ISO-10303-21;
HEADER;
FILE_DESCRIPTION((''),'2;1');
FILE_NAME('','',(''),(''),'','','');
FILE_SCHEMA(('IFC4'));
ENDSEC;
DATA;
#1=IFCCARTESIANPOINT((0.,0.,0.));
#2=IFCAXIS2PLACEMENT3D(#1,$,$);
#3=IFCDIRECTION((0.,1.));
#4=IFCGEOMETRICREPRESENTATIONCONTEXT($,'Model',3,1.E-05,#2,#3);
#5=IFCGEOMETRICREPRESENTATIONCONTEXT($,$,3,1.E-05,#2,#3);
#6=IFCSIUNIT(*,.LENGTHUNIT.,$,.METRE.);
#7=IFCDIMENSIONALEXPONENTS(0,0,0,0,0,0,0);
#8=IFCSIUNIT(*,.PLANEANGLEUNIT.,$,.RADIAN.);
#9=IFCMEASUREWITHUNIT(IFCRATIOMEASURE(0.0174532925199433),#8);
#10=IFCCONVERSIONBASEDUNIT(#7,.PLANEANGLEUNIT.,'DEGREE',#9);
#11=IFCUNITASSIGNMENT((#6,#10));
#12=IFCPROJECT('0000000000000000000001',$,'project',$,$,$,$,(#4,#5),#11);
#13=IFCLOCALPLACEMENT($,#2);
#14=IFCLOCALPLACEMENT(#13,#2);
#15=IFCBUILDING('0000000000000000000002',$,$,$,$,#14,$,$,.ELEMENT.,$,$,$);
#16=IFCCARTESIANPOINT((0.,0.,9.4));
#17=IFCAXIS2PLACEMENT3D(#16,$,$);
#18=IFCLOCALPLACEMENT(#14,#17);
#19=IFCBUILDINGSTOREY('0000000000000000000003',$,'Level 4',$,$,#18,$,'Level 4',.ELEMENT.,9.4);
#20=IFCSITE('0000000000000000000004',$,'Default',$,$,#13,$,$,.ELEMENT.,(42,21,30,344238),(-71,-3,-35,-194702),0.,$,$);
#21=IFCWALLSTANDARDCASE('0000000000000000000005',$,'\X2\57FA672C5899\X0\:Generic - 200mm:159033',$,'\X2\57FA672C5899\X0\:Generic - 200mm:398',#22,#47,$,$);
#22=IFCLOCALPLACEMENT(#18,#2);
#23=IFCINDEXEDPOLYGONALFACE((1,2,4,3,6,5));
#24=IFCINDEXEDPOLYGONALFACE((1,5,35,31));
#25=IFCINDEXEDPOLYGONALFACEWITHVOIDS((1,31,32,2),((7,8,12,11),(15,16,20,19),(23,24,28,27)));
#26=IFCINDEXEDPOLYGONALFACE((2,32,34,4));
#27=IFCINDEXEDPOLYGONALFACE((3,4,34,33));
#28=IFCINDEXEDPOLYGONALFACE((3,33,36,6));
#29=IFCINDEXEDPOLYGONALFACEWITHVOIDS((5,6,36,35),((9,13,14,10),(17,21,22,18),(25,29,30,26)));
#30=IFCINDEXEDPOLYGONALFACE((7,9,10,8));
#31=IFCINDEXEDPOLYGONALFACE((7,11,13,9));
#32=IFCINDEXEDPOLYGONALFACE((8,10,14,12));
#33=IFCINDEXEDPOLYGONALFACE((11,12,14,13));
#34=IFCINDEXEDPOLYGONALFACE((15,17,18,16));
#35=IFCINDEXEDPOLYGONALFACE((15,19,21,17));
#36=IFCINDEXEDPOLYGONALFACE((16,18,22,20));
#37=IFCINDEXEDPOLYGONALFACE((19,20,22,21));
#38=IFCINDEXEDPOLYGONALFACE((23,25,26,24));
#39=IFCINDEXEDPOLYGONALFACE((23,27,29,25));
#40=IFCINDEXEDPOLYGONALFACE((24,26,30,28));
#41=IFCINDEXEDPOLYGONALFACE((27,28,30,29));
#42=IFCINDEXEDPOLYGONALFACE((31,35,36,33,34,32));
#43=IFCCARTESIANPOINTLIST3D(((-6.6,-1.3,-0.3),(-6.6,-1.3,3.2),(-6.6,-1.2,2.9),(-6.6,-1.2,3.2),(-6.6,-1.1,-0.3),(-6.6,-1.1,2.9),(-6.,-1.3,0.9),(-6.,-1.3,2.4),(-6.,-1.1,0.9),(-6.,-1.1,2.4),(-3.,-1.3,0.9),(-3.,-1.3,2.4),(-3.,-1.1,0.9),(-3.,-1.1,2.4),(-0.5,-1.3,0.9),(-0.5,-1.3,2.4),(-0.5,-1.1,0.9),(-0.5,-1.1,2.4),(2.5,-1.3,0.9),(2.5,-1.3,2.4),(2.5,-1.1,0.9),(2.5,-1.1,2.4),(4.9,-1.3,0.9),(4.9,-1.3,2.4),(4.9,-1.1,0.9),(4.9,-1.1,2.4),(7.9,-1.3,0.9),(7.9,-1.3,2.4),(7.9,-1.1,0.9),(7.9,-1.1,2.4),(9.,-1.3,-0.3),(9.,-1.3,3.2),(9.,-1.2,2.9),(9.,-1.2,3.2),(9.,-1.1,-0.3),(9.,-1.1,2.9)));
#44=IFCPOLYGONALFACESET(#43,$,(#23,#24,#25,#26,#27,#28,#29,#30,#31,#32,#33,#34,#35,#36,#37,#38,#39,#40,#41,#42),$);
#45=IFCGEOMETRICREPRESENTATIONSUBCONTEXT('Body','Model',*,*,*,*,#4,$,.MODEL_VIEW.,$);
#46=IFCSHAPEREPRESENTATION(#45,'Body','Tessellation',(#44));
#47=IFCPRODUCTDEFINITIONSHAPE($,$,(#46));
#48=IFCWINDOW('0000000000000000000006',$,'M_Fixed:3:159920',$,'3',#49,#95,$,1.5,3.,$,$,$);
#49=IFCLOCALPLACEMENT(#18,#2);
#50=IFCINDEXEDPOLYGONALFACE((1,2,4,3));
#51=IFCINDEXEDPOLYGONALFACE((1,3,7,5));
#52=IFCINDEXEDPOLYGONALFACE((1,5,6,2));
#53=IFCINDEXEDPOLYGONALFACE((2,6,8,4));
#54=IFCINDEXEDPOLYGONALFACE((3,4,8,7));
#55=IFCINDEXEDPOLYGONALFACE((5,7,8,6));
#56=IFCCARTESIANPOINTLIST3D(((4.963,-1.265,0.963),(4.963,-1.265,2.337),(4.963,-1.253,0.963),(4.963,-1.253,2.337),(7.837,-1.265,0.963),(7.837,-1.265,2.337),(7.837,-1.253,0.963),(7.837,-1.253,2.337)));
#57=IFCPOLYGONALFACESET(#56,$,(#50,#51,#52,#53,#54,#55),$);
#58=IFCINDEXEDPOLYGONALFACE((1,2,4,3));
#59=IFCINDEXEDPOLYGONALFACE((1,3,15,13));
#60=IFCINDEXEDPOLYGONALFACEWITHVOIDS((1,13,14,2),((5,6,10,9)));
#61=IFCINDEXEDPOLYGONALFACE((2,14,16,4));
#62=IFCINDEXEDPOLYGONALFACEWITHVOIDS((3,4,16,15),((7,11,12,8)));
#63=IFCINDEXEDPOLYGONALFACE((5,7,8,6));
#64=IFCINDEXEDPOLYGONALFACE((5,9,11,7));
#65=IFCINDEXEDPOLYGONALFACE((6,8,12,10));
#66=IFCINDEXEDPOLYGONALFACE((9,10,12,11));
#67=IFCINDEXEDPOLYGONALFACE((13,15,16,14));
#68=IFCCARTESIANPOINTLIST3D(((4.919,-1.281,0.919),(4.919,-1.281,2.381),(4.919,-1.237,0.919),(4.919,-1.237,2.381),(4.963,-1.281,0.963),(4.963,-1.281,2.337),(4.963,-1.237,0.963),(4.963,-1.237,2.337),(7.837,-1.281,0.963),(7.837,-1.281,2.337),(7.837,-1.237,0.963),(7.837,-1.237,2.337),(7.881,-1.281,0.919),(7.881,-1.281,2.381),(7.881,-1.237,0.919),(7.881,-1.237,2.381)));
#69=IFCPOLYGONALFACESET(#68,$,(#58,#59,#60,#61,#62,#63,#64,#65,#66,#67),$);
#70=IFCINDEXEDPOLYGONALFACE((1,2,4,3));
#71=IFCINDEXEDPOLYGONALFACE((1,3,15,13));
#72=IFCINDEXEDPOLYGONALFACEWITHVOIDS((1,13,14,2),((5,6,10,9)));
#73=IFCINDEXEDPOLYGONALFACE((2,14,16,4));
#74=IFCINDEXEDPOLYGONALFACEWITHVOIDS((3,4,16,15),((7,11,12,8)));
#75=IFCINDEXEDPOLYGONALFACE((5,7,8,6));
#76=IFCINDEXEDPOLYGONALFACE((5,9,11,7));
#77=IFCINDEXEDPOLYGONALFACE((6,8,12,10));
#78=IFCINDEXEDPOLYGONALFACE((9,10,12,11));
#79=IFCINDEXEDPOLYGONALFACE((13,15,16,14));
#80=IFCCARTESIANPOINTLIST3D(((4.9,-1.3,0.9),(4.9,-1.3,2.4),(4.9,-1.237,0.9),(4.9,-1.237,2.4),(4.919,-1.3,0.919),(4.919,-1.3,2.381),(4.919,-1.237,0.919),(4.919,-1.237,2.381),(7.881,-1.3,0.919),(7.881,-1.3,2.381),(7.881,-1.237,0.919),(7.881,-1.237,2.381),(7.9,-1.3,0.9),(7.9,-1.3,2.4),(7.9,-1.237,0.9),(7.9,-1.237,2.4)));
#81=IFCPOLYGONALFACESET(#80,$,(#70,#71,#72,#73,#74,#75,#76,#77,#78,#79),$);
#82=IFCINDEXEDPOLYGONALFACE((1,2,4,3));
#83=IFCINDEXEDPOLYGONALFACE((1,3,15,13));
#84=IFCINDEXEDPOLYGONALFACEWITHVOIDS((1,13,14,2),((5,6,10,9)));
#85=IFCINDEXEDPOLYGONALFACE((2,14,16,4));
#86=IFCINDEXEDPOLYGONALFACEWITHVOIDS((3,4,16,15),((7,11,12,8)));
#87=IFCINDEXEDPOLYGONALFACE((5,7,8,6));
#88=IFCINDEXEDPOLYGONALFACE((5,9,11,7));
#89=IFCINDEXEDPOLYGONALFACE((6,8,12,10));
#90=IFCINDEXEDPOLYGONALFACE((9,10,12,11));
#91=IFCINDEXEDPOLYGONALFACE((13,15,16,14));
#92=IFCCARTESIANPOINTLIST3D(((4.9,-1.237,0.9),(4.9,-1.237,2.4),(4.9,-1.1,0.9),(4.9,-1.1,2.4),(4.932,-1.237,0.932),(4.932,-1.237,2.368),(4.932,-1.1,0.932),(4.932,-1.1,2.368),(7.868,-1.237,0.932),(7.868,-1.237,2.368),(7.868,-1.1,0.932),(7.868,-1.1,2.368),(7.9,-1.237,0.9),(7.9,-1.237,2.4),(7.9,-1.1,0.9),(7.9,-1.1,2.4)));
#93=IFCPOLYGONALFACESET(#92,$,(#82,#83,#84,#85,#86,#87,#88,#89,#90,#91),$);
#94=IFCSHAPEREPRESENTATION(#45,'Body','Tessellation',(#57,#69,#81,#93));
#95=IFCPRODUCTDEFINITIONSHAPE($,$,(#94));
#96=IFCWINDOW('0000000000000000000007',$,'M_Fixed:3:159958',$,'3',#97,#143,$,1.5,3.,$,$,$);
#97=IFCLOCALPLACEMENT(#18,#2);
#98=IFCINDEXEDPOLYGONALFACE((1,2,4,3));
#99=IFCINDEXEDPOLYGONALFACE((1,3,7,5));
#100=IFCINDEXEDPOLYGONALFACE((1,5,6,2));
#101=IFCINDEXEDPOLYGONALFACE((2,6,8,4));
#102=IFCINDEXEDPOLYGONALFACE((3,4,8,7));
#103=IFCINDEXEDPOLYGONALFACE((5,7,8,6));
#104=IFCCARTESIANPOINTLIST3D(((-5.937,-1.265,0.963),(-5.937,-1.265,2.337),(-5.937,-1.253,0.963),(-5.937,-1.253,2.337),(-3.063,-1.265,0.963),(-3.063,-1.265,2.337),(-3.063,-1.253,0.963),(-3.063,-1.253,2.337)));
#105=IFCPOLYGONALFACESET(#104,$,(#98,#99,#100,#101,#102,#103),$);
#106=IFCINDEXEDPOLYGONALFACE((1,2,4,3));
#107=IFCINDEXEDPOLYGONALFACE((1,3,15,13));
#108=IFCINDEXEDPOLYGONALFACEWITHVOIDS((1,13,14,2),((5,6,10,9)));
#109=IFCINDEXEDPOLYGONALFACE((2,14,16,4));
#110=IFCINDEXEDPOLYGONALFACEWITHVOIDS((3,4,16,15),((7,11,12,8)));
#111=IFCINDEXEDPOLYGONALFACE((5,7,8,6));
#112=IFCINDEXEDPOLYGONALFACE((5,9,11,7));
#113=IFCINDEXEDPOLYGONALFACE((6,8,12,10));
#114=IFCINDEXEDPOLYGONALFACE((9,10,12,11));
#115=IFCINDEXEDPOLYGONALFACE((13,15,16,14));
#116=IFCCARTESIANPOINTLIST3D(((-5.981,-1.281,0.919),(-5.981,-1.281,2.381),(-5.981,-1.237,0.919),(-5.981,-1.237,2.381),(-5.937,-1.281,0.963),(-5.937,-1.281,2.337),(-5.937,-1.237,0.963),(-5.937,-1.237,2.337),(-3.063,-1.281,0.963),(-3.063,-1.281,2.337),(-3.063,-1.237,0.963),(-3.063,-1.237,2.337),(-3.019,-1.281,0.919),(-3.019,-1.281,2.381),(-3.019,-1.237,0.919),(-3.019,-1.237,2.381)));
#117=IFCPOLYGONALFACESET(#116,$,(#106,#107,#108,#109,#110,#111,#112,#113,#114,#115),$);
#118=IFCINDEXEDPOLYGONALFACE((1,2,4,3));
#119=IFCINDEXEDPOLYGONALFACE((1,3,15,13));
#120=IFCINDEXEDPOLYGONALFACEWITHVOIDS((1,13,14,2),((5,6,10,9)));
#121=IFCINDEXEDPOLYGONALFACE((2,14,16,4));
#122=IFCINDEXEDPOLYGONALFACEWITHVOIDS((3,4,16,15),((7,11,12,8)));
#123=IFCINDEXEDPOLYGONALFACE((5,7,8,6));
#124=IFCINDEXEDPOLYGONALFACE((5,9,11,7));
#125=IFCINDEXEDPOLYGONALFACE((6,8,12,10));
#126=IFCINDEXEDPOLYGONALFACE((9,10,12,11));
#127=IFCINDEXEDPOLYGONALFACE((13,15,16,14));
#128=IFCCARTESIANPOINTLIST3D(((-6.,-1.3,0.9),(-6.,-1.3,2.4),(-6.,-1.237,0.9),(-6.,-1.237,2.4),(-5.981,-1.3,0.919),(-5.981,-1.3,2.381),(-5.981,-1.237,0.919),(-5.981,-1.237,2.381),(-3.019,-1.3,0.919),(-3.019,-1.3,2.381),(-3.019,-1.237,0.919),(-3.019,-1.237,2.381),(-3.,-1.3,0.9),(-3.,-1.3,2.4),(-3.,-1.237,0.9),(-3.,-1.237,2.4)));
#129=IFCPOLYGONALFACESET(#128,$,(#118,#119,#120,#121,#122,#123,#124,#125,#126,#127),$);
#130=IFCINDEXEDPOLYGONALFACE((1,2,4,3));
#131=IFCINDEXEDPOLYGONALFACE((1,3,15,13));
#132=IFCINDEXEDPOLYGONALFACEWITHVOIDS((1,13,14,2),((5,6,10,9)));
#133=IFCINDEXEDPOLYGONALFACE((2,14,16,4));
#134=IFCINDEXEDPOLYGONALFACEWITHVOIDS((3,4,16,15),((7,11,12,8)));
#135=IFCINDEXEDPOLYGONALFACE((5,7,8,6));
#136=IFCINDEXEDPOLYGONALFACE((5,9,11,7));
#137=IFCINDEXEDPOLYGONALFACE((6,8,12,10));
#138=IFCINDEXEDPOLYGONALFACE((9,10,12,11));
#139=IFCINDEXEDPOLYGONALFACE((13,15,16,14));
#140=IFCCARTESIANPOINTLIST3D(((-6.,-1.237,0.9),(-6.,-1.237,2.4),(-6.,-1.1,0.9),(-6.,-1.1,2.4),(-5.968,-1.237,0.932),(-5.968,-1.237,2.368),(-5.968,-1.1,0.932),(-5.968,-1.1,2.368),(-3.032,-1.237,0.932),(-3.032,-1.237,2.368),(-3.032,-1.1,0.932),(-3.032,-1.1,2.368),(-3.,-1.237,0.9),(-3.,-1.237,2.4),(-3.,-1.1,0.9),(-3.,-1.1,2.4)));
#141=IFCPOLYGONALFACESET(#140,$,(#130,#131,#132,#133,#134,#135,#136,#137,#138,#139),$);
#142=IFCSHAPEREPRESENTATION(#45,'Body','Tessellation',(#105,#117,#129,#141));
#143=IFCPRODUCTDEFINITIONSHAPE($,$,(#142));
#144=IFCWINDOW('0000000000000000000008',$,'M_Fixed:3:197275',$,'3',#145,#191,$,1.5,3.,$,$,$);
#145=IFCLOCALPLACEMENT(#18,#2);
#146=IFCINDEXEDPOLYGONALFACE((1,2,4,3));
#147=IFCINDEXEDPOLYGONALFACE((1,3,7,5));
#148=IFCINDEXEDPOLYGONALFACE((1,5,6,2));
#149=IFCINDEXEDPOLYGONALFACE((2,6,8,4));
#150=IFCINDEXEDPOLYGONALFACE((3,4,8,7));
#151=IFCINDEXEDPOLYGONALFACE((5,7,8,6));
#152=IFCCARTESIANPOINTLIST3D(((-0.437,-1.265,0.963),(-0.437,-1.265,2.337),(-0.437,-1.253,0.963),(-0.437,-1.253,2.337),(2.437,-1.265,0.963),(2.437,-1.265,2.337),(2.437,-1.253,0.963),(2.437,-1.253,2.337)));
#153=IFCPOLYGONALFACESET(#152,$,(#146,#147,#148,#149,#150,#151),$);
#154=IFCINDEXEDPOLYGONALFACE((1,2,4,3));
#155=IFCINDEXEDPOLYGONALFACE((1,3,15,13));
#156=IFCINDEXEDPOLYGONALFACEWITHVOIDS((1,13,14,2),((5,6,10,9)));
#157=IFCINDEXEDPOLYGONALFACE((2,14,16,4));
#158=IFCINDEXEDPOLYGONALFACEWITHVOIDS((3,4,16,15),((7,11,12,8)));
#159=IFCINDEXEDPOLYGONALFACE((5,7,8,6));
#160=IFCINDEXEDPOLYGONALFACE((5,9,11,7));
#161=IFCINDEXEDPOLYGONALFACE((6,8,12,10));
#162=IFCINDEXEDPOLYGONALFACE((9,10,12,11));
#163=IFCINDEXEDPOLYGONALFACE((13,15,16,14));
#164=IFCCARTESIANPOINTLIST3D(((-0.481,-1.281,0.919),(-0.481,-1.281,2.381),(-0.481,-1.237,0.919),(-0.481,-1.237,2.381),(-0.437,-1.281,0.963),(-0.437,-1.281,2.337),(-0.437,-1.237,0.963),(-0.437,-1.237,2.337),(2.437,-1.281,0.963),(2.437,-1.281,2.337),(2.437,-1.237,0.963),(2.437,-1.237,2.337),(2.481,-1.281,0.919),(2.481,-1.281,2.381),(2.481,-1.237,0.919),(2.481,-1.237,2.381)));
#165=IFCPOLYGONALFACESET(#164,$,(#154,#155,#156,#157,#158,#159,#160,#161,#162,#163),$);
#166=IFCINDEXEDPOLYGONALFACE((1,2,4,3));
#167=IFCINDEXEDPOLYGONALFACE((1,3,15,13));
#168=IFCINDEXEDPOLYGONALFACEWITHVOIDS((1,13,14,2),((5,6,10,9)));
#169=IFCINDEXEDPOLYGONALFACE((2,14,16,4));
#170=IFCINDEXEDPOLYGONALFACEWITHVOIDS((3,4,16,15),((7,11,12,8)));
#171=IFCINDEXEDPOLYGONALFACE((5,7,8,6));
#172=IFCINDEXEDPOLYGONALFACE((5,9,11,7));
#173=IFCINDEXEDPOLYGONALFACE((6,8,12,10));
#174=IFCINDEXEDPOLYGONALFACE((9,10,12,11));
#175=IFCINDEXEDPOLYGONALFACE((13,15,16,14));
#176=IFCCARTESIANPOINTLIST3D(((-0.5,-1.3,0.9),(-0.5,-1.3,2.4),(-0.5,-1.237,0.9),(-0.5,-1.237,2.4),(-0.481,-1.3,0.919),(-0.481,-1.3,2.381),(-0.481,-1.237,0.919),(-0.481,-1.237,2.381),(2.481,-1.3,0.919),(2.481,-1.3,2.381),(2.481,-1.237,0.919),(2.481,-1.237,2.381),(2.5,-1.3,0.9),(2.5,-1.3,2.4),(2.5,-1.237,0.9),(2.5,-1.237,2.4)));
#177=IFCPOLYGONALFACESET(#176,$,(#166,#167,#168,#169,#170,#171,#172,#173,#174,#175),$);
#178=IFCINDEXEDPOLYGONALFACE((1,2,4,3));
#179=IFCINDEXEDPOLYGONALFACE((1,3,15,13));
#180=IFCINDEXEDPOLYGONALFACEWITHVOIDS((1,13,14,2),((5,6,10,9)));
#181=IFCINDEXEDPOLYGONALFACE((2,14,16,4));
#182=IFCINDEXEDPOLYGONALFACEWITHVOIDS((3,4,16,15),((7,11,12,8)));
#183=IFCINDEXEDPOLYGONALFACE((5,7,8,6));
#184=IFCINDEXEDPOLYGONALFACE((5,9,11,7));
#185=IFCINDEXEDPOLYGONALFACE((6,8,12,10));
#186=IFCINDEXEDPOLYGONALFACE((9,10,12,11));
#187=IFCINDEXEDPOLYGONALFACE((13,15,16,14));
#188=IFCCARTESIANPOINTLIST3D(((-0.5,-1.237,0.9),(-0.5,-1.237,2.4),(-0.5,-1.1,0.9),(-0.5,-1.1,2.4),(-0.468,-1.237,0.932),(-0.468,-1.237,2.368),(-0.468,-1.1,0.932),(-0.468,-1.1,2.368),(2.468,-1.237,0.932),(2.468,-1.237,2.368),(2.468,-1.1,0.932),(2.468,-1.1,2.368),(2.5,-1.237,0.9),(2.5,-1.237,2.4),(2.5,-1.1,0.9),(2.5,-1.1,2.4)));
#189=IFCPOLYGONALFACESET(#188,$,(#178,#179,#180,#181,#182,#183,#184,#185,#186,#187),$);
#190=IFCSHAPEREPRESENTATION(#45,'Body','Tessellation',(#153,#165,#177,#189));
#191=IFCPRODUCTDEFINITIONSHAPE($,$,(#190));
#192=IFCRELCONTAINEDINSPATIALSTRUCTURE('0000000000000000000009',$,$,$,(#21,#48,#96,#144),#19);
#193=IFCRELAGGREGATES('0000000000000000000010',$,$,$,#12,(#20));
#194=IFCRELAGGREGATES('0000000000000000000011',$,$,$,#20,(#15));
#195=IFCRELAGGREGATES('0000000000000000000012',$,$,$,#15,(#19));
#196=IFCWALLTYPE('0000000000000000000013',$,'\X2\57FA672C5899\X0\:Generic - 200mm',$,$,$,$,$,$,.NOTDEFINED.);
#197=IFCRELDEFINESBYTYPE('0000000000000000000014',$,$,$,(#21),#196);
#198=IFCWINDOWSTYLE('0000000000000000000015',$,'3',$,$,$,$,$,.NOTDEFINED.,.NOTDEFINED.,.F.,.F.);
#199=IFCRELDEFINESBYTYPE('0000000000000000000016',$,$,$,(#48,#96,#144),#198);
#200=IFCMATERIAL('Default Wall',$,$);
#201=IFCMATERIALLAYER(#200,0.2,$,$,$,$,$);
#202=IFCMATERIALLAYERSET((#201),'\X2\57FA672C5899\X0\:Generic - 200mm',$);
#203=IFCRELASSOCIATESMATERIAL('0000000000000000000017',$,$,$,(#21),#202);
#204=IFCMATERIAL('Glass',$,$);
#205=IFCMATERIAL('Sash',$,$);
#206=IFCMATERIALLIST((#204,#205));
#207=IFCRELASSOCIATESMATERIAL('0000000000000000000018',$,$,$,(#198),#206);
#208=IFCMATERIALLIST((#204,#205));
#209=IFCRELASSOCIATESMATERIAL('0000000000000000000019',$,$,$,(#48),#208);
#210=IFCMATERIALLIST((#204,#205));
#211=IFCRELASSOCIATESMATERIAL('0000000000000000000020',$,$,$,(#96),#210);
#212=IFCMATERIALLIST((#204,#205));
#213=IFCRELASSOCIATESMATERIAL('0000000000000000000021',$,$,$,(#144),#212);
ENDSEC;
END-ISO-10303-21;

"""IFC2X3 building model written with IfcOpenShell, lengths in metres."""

from ifc_helpers import new_model, entity, si_unit, converted_unit, direction, frame, frame_2d, origin, place, context, subcontext, project, spatial, polyline, rectangle, outline, extrude, clip, bounded_halfspace, source, transform, mapped, material, material_list, layer, layer_set, layer_usage, type_object, type_shapes, element, fill, save


model = new_model("IFC2X3")

# Units and contexts
model_context = context("Model", 3, precision=1e-05, world=origin(), true_north=direction((0.0, 1.0)))
context_of_model = context(None, 3, precision=1e-05, world=origin(), true_north=direction((0.0, 1.0)))
body_context = subcontext(model_context, "Body", "Model", "MODEL_VIEW")
ifc_project = project(units=[si_unit("LENGTHUNIT", "METRE"), converted_unit("PLANEANGLEUNIT", "DEGREE", entity("IfcRatioMeasure", 0.0174532925199433), si_unit("PLANEANGLEUNIT", "RADIAN"), dimensions=[0, 0, 0, 0, 0, 0, 0])], contexts=[model_context, context_of_model])

# Site, building, storey
site_placement = place(None, origin())
site = spatial("IfcSite", under=ifc_project, at=site_placement, Name="Default", CompositionType="ELEMENT", RefLatitude=(42, 21, 30, 344238), RefLongitude=(-71, -3, -35, -194702), RefElevation=0.0)
building_placement = place(site_placement, origin())
building = spatial("IfcBuilding", under=site, at=building_placement, CompositionType="ELEMENT")
storey_placement = place(building_placement, frame((0.0, 0.0, 9.4)))
storey = spatial("IfcBuildingStorey", under=building, at=storey_placement, Name="Level 4", LongName="Level 4", CompositionType="ELEMENT", Elevation=9.4)

# Wall, openings, windows
ifc_material_1 = material(Name="Default Wall")
ifc_layer_1 = layer(ifc_material_1, 0.2)
ifc_layer_set_1 = layer_set([ifc_layer_1], Name="基本墙:Generic - 200mm")
ifc_layer_usage_1 = layer_usage(ifc_layer_set_1, "AXIS2", "NEGATIVE", 0.1)
wall_type_1 = type_object("IfcWallType", Name="基本墙:Generic - 200mm", PredefinedType="NOTDEFINED")
wall_1_placement = place(storey_placement, frame((9.0, -1.2, -0.3), z_axis=(0.0, 0.0, 1.0), x_axis=(-1.0, 0.0, 0.0)))
wall_1 = element("IfcWallStandardCase", 1, at=wall_1_placement, inside=storey, type_object=wall_type_1, material=ifc_layer_usage_1, Name="基本墙:Generic - 200mm:159033", ObjectType="基本墙:Generic - 200mm:398", context=body_context, shape_type="Clipping", body=[
    clip(clip(extrude(rectangle(XDim=15.6, YDim=0.2, at=frame_2d((7.8, 0.0), x_axis=(-1.0, 0.0))), origin(), (0.0, 0.0, 1.0), 3.5), bounded_halfspace(frame((15.6, 0.0, 3.2), z_axis=(0.0, 0.0, -1.0), x_axis=(0.0, 1.0, 0.0)), True, frame((15.6, 0.0, 3.2), z_axis=(0.0, 0.0, -1.0), x_axis=(0.0, 1.0, 0.0)), polyline([(0.0, 0.0), (-0.1, 0.0), (-0.1, -0.1), (-0.1, -5.1), (-0.1, -5.2), (-0.1, -10.0), (-0.1, -10.1), (-0.1, -15.6), (0.0, -15.6), (0.0, 0.0)]))), bounded_halfspace(frame((0.0, 0.0, 3.2), z_axis=(0.0, 1.0, 0.0), x_axis=(0.0, 0.0, 1.0)), True, frame((0.0, 0.0, 3.2), z_axis=(0.0, 1.0, 0.0), x_axis=(0.0, 0.0, 1.0)), polyline([(0.0, 0.0), (0.3, 0.0), (0.3, 15.6), (0.0, 15.6), (0.0, 0.0)]))),
])
opening_1_placement = place(wall_1_placement, frame((1.1, -0.1, 1.2)))
opening_1 = element("IfcOpeningElement", 2, at=opening_1_placement, cuts=wall_1, ObjectType="Opening", context=body_context, shape_type="SweptSolid", body=[
    extrude(rectangle(XDim=1.5, YDim=3.0, at=frame_2d((0.75, 1.5), x_axis=(1.0, 0.0))), frame((0.0, 0.0, 0.0), z_axis=(0.0, 1.0, 0.0), x_axis=(0.0, 0.0, 1.0)), (0.0, 0.0, 1.0), 0.2),
])
opening_2_placement = place(wall_1_placement, frame((12.0, -0.1, 1.2)))
opening_2 = element("IfcOpeningElement", 3, at=opening_2_placement, cuts=wall_1, ObjectType="Opening", context=body_context, shape_type="SweptSolid", body=[
    extrude(rectangle(XDim=1.5, YDim=3.0, at=frame_2d((0.75, 1.5), x_axis=(1.0, 0.0))), frame((0.0, 0.0, 0.0), z_axis=(0.0, 1.0, 0.0), x_axis=(0.0, 0.0, 1.0)), (0.0, 0.0, 1.0), 0.2),
])
opening_3_placement = place(wall_1_placement, frame((6.5, -0.1, 1.2)))
opening_3 = element("IfcOpeningElement", 4, at=opening_3_placement, cuts=wall_1, ObjectType="Opening", context=body_context, shape_type="SweptSolid", body=[
    extrude(rectangle(XDim=1.5, YDim=3.0, at=frame_2d((0.75, 1.5), x_axis=(1.0, 0.0))), frame((0.0, 0.0, 0.0), z_axis=(0.0, 1.0, 0.0), x_axis=(0.0, 0.0, 1.0)), (0.0, 0.0, 1.0), 0.2),
])
ifc_material_2 = material(Name="Glass")
ifc_material_3 = material(Name="Sash")
ifc_material_list_1 = material_list([ifc_material_2, ifc_material_3])
ifc_material_list_2 = material_list([ifc_material_2, ifc_material_3])
window_style = type_object("IfcWindowStyle", Name="3", ConstructionType="NOTDEFINED", OperationType="NOTDEFINED", ParameterTakesPrecedence=False, Sizeable=False, material=ifc_material_list_2)
shared_shape_1 = source(origin(), body_context, "Body", "SweptSolid", [
    extrude(rectangle(XDim=0.012, YDim=2.874, at=frame_2d((0.0, 0.0), x_axis=(1.0, 0.0))), frame((1.5, 0.159, 0.063), z_axis=(0.0, 0.0, 1.0), x_axis=(0.0, -1.0, 0.0)), (0.0, 0.0, 1.0), 1.374),
    extrude(outline(polyline([(-1.481, -0.731), (1.481, -0.731), (1.481, 0.731), (-1.481, 0.731), (-1.481, -0.731)]), holes=[polyline([(-1.437, -0.687), (-1.437, 0.687), (1.437, 0.687), (1.437, -0.687), (-1.437, -0.687)])]), frame((1.5, 0.137, 0.75), z_axis=(0.0, 1.0, 0.0), x_axis=(1.0, 0.0, 0.0)), (0.0, 0.0, 1.0), 0.044),
    extrude(outline(polyline([(-1.5, -0.75), (1.5, -0.75), (1.5, 0.75), (-1.5, 0.75), (-1.5, -0.75)]), holes=[polyline([(-1.481, -0.731), (-1.481, 0.731), (1.481, 0.731), (1.481, -0.731), (-1.481, -0.731)])]), frame((1.5, 0.137, 0.75), z_axis=(0.0, 1.0, 0.0), x_axis=(1.0, 0.0, 0.0)), (0.0, 0.0, 1.0), 0.063),
    extrude(outline(polyline([(-1.5, -0.75), (1.5, -0.75), (1.5, 0.75), (-1.5, 0.75), (-1.5, -0.75)]), holes=[polyline([(-1.468, -0.718), (-1.468, 0.718), (1.468, 0.718), (1.468, -0.718), (-1.468, -0.718)])]), frame((1.5, 0.0, 0.75), z_axis=(0.0, 1.0, 0.0), x_axis=(1.0, 0.0, 0.0)), (0.0, 0.0, 1.0), 0.137),
])
type_shapes(window_style, [shared_shape_1])
window_1_placement = place(opening_1_placement, origin())
window_1 = element("IfcWindow", 5, at=window_1_placement, inside=storey, type_object=window_style, material=ifc_material_list_1, Name="M_Fixed:3:159920", ObjectType="3", OverallHeight=1.5, OverallWidth=3.0, context=body_context, shape_type="MappedRepresentation", body=[
    mapped(shared_shape_1, transform((0.0, 0.0, 0.0), scale=1.0)),
])
fill(opening_1, window_1)
ifc_material_list_3 = material_list([ifc_material_2, ifc_material_3])
window_2_placement = place(opening_2_placement, origin())
window_2 = element("IfcWindow", 6, at=window_2_placement, inside=storey, type_object=window_style, material=ifc_material_list_3, Name="M_Fixed:3:159958", ObjectType="3", OverallHeight=1.5, OverallWidth=3.0, context=body_context, shape_type="MappedRepresentation", body=[
    mapped(shared_shape_1, transform((0.0, 0.0, 0.0), scale=1.0)),
])
fill(opening_2, window_2)
ifc_material_list_4 = material_list([ifc_material_2, ifc_material_3])
window_3_placement = place(opening_3_placement, origin())
window_3 = element("IfcWindow", 7, at=window_3_placement, inside=storey, type_object=window_style, material=ifc_material_list_4, Name="M_Fixed:3:197275", ObjectType="3", OverallHeight=1.5, OverallWidth=3.0, context=body_context, shape_type="MappedRepresentation", body=[
    mapped(shared_shape_1, transform((0.0, 0.0, 0.0), scale=1.0)),
])
fill(opening_3, window_3)

save(model, "model.ifc")
